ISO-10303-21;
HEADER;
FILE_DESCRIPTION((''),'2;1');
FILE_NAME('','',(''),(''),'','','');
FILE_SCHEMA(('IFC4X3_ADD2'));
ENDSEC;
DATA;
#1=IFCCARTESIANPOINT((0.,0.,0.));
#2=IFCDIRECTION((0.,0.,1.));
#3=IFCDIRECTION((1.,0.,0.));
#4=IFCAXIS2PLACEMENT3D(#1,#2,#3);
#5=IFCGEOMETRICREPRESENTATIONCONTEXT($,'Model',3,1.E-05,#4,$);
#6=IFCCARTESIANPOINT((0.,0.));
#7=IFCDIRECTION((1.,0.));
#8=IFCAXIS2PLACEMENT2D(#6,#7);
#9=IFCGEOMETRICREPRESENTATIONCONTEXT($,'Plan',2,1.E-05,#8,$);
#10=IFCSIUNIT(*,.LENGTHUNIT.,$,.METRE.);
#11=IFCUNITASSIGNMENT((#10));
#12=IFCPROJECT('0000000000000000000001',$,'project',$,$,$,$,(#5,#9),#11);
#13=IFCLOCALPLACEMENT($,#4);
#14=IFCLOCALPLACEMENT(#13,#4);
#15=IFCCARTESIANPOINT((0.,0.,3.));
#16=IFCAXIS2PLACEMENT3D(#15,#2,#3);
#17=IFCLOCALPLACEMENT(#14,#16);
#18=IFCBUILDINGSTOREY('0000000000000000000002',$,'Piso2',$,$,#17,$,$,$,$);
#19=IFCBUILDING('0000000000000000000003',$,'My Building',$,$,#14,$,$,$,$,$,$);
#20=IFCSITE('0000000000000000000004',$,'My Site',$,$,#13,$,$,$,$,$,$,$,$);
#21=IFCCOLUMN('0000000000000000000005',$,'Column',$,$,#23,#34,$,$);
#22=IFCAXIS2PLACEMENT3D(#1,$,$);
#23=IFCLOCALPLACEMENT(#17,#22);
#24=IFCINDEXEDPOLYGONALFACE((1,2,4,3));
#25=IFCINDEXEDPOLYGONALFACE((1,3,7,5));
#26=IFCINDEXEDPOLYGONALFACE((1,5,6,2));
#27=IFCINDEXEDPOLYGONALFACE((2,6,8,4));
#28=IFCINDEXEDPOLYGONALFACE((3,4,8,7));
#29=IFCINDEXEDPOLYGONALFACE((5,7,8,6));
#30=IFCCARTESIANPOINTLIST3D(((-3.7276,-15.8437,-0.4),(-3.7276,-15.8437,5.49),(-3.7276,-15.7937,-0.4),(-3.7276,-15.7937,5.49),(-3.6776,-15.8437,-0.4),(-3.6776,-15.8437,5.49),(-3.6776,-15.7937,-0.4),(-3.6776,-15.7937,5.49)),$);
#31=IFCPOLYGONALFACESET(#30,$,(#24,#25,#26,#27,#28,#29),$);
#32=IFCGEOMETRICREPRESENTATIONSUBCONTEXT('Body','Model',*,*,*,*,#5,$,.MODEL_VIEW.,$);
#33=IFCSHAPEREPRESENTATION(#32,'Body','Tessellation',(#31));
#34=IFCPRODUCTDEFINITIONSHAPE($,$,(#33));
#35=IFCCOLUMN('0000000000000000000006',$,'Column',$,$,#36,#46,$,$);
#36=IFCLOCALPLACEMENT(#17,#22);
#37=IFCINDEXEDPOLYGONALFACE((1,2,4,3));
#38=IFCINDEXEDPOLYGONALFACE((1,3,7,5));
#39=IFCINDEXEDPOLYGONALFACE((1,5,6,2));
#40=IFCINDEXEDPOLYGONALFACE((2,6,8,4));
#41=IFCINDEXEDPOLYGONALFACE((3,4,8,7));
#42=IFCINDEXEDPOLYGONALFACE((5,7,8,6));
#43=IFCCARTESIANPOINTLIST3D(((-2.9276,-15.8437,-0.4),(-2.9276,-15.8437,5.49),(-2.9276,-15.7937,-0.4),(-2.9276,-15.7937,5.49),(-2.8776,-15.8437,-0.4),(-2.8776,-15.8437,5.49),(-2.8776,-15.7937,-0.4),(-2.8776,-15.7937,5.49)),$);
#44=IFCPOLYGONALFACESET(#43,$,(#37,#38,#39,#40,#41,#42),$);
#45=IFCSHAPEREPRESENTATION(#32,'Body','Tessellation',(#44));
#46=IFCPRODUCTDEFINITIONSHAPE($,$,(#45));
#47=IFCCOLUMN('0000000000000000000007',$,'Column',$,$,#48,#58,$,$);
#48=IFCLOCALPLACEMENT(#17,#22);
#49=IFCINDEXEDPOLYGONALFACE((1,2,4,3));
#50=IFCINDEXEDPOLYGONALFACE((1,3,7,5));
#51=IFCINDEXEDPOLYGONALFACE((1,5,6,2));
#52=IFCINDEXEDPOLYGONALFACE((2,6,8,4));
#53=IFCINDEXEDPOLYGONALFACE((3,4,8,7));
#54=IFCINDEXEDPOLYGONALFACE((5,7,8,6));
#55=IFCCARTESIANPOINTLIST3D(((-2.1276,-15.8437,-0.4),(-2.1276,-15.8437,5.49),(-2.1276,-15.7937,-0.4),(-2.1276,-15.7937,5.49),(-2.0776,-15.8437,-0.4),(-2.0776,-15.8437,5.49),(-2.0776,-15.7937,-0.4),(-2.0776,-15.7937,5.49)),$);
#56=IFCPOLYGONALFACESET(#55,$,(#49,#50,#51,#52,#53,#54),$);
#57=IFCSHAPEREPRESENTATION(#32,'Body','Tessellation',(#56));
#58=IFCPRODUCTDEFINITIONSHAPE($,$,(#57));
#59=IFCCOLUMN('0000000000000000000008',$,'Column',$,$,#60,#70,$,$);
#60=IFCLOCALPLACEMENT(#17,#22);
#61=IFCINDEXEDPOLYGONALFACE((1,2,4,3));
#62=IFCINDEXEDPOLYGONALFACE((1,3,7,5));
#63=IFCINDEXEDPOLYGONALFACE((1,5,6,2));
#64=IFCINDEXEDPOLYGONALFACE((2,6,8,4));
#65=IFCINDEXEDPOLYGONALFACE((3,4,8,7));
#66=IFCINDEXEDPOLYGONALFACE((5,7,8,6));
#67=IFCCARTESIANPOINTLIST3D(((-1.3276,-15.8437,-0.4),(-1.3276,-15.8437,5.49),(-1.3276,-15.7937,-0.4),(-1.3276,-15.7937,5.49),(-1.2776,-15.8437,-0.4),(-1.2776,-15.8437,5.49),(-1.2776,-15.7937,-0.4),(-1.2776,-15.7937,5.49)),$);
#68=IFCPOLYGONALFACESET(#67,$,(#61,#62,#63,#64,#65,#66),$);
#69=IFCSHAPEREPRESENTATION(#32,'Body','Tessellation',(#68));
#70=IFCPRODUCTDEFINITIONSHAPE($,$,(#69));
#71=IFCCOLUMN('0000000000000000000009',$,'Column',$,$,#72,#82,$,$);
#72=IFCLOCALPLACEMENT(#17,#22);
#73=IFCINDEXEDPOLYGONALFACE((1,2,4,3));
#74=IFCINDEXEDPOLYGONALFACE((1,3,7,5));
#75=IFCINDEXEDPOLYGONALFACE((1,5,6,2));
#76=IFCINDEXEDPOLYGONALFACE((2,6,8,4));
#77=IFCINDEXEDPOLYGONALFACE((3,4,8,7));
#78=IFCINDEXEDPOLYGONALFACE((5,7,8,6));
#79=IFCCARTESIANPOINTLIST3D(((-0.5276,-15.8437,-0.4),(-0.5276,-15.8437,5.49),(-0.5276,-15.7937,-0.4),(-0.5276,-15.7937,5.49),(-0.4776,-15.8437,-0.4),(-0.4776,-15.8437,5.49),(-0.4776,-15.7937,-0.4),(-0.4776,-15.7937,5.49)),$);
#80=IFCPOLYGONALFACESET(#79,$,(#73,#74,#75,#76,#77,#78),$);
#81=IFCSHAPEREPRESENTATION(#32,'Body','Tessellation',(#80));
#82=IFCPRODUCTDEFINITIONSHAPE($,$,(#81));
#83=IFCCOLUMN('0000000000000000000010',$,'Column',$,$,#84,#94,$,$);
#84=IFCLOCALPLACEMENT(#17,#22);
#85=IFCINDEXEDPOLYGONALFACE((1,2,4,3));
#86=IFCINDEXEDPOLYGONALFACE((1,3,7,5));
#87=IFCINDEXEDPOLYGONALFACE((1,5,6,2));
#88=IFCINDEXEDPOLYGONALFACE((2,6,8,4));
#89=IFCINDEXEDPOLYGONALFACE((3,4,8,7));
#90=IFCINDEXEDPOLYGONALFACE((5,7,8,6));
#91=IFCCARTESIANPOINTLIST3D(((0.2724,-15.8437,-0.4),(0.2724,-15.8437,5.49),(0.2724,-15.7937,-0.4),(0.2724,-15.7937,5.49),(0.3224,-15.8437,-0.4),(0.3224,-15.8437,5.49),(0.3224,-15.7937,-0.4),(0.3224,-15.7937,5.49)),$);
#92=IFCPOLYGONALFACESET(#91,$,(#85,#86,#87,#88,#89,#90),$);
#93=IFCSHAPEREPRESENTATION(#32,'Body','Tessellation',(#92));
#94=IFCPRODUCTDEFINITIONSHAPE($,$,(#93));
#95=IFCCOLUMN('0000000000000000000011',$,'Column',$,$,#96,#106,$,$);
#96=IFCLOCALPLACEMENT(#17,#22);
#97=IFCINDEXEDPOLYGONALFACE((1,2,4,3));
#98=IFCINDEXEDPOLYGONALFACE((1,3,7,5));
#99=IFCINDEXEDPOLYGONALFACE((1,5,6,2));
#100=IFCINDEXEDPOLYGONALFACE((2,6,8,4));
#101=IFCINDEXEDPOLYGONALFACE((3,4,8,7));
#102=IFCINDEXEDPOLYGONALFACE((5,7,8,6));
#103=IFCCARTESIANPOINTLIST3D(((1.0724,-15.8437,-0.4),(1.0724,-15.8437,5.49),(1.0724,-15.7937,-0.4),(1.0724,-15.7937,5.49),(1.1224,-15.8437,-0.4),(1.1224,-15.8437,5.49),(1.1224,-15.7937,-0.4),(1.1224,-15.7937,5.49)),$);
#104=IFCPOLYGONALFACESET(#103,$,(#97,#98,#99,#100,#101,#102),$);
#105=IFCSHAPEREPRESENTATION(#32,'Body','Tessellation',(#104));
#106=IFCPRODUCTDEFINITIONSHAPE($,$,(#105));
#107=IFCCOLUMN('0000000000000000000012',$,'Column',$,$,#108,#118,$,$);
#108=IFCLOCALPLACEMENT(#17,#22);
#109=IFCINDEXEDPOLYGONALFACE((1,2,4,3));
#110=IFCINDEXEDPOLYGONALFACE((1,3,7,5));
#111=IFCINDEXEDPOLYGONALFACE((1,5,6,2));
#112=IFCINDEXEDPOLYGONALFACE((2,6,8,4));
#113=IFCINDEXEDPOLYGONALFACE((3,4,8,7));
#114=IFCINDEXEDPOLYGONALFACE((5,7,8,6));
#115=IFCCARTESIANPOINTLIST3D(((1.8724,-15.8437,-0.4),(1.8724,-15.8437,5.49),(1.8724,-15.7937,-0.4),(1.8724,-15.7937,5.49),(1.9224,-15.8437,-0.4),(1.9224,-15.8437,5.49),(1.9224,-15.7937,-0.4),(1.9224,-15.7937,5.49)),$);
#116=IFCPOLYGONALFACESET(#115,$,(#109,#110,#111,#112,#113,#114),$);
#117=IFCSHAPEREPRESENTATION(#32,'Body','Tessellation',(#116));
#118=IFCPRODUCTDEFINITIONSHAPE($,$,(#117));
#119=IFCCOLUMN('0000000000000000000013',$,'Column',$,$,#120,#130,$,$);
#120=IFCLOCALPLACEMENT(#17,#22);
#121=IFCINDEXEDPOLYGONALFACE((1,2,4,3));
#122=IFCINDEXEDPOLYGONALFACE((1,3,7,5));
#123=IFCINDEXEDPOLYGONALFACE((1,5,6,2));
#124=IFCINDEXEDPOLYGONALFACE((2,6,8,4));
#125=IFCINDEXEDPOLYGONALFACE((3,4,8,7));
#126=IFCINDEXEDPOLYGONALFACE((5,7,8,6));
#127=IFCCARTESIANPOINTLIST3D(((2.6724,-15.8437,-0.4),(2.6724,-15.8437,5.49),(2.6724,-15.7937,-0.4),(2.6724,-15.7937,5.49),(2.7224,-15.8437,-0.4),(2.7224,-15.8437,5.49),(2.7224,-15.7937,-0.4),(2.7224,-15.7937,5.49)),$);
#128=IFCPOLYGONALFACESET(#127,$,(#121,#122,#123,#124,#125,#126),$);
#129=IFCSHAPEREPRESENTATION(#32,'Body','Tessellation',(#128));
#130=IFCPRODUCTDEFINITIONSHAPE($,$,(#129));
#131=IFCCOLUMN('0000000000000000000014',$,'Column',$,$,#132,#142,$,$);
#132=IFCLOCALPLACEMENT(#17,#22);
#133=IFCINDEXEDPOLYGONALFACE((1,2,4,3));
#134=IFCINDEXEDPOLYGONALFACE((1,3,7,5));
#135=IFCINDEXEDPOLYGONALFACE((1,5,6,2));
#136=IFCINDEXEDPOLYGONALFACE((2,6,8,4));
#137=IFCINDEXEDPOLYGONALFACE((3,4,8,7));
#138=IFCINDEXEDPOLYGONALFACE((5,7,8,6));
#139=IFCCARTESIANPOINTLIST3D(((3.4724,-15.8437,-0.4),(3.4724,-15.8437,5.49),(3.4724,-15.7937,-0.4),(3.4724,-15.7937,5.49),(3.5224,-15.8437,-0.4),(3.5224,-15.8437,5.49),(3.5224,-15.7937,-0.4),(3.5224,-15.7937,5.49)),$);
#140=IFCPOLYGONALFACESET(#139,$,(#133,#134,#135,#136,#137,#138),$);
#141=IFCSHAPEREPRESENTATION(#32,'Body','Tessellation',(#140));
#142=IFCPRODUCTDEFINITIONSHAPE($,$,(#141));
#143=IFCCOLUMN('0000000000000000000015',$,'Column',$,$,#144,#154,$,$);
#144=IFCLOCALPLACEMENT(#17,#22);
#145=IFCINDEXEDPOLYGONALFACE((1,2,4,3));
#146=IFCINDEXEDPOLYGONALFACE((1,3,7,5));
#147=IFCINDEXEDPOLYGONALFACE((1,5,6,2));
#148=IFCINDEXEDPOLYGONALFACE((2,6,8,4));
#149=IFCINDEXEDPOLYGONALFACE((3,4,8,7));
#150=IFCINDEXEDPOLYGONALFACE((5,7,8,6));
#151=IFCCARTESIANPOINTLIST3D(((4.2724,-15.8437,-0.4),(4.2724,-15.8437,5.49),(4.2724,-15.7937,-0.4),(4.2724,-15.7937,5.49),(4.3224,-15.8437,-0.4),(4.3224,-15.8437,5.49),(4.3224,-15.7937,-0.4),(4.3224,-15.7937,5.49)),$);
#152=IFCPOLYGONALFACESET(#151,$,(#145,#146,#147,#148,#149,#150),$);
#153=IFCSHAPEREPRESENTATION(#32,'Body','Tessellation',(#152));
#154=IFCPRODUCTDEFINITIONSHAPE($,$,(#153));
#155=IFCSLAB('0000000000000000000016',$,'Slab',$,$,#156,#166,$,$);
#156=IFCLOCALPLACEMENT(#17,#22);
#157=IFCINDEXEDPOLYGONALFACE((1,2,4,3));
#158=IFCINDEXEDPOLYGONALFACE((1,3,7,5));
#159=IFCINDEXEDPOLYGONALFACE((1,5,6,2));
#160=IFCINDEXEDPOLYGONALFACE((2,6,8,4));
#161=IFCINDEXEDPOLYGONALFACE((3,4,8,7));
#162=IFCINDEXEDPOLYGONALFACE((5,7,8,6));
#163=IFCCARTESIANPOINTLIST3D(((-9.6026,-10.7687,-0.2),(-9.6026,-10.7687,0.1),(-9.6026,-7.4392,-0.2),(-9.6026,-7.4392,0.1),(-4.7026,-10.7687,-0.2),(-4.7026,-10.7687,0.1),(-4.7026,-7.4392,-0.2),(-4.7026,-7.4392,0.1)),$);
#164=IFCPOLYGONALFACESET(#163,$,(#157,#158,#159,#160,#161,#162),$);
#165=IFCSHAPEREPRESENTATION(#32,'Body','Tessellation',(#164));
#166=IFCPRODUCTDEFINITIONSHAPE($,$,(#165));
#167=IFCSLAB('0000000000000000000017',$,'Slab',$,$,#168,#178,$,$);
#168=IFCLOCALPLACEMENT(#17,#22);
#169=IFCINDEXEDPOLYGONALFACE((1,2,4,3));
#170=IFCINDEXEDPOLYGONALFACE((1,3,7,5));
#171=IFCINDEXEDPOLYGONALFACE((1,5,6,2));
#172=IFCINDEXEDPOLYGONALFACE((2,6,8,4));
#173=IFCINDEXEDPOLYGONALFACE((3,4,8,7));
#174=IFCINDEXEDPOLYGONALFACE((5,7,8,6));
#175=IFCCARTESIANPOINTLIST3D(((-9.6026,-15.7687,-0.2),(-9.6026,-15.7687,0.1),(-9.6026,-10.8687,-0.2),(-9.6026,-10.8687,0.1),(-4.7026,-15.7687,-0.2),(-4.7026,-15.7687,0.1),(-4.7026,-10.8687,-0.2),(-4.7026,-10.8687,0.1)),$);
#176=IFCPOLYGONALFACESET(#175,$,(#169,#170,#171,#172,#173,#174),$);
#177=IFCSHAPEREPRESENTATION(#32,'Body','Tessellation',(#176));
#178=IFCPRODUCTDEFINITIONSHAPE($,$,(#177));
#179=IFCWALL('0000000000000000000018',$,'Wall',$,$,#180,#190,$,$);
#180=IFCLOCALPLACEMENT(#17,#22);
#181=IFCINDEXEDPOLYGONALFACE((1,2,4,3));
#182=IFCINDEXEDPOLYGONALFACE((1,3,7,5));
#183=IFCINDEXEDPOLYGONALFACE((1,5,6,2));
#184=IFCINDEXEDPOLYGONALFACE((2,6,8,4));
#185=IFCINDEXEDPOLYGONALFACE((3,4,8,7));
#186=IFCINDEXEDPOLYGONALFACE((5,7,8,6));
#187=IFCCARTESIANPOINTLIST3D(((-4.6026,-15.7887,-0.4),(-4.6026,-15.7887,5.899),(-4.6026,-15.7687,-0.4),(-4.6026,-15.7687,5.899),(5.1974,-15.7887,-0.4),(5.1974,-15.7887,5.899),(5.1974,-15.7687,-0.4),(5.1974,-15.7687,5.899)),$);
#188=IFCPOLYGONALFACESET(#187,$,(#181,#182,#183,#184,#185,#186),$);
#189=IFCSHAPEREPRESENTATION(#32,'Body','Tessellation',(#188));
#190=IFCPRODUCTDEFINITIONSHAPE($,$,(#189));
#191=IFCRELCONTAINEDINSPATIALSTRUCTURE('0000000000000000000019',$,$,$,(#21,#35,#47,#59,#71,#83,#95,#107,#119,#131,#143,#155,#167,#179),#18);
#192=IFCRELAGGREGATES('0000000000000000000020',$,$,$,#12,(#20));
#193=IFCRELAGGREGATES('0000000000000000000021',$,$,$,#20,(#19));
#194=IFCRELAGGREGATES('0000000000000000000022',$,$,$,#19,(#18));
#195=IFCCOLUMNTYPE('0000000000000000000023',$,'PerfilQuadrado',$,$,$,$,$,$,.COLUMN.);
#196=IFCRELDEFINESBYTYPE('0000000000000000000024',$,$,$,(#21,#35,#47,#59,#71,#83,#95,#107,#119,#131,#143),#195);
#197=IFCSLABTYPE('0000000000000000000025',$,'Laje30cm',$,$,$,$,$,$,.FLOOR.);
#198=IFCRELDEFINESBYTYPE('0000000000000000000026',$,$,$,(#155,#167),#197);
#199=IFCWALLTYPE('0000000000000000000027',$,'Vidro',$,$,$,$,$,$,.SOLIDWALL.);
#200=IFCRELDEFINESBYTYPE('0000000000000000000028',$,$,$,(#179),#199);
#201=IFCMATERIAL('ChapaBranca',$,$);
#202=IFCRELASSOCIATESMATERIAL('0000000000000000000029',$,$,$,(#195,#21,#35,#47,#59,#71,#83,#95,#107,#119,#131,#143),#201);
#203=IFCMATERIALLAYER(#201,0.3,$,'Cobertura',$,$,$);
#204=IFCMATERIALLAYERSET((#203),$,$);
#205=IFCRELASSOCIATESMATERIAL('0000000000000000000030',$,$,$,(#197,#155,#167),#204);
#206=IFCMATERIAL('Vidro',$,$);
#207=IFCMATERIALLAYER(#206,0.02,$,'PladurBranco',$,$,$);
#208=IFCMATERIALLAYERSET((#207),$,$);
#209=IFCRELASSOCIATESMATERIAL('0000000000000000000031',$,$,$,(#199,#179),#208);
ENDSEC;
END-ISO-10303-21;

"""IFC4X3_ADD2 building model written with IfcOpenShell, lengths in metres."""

from ifc_helpers import new_model, si_unit, frame, origin_with_axes, origin_2d, origin_2d_with_axis, place, context, subcontext, project, spatial, line, indexed_curve, rectangle, outline, extrude, material, layer, layer_set, layer_usage, material_profile, profile_set, profile_usage, type_object, element, save


model = new_model("IFC4X3_ADD2")

# Units and contexts
model_context = context("Model", 3, precision=1e-05, world=origin_with_axes())
plan_context = context("Plan", 2, precision=1e-05, world=origin_2d_with_axis())
body_context = subcontext(model_context, "Body", "Model", "MODEL_VIEW")
ifc_project = project(units=[si_unit("LENGTHUNIT", "METRE")], contexts=[model_context, plan_context])

# Site, building, storey
site_placement = place(None, origin_with_axes())
site = spatial("IfcSite", under=ifc_project, at=site_placement, Name="My Site")
building_placement = place(site_placement, origin_with_axes())
building = spatial("IfcBuilding", under=site, at=building_placement, Name="My Building")
storey_placement = place(building_placement, frame((0.0, 0.0, 3.0), z_axis=(0.0, 0.0, 1.0), x_axis=(1.0, 0.0, 0.0)))
storey = spatial("IfcBuildingStorey", under=building, at=storey_placement, Name="Piso2")

# Columns
ifc_material_1 = material(Name="ChapaBranca")
ifc_material_profile = material_profile(ifc_material_1, rectangle(XDim=0.05, YDim=0.05, at=origin_2d()))
ifc_profile_set = profile_set([ifc_material_profile])
ifc_profile_usage_1 = profile_usage(ifc_profile_set, cardinal=5)
column_type = type_object("IfcColumnType", Name="PerfilQuadrado", PredefinedType="COLUMN", material=ifc_profile_set)
column_1_placement = place(storey_placement, frame((-3.7026, -15.8187, -0.4), z_axis=(0.0, 0.0, 1.0), x_axis=(0.0, 1.0, 0.0)))
element("IfcColumn", 1, at=column_1_placement, inside=storey, type_object=column_type, material=ifc_profile_usage_1, Name="Column", context=body_context, shape_type="SweptSolid", body=[
    extrude(rectangle(XDim=0.05, YDim=0.05, at=origin_2d()), origin_with_axes(), (0.0, 0.0, 1.0), 5.89),
])
ifc_profile_usage_2 = profile_usage(ifc_profile_set, cardinal=5)
column_2_placement = place(storey_placement, frame((-2.9026, -15.8187, -0.4), z_axis=(0.0, 0.0, 1.0), x_axis=(0.0, 1.0, 0.0)))
element("IfcColumn", 2, at=column_2_placement, inside=storey, type_object=column_type, material=ifc_profile_usage_2, Name="Column", context=body_context, shape_type="SweptSolid", body=[
    extrude(rectangle(XDim=0.05, YDim=0.05, at=origin_2d()), origin_with_axes(), (0.0, 0.0, 1.0), 5.89),
])
ifc_profile_usage_3 = profile_usage(ifc_profile_set, cardinal=5)
column_3_placement = place(storey_placement, frame((-2.1026, -15.8187, -0.4), z_axis=(0.0, 0.0, 1.0), x_axis=(0.0, 1.0, 0.0)))
element("IfcColumn", 3, at=column_3_placement, inside=storey, type_object=column_type, material=ifc_profile_usage_3, Name="Column", context=body_context, shape_type="SweptSolid", body=[
    extrude(rectangle(XDim=0.05, YDim=0.05, at=origin_2d()), origin_with_axes(), (0.0, 0.0, 1.0), 5.89),
])
ifc_profile_usage_4 = profile_usage(ifc_profile_set, cardinal=5)
column_4_placement = place(storey_placement, frame((-1.3026, -15.8187, -0.4), z_axis=(0.0, 0.0, 1.0), x_axis=(0.0, 1.0, 0.0)))
element("IfcColumn", 4, at=column_4_placement, inside=storey, type_object=column_type, material=ifc_profile_usage_4, Name="Column", context=body_context, shape_type="SweptSolid", body=[
    extrude(rectangle(XDim=0.05, YDim=0.05, at=origin_2d()), origin_with_axes(), (0.0, 0.0, 1.0), 5.89),
])
ifc_profile_usage_5 = profile_usage(ifc_profile_set, cardinal=5)
column_5_placement = place(storey_placement, frame((-0.5026, -15.8187, -0.4), z_axis=(0.0, 0.0, 1.0), x_axis=(0.0, 1.0, 0.0)))
element("IfcColumn", 5, at=column_5_placement, inside=storey, type_object=column_type, material=ifc_profile_usage_5, Name="Column", context=body_context, shape_type="SweptSolid", body=[
    extrude(rectangle(XDim=0.05, YDim=0.05, at=origin_2d()), origin_with_axes(), (0.0, 0.0, 1.0), 5.89),
])
ifc_profile_usage_6 = profile_usage(ifc_profile_set, cardinal=5)
column_6_placement = place(storey_placement, frame((0.2974, -15.8187, -0.4), z_axis=(0.0, 0.0, 1.0), x_axis=(0.0, 1.0, 0.0)))
element("IfcColumn", 6, at=column_6_placement, inside=storey, type_object=column_type, material=ifc_profile_usage_6, Name="Column", context=body_context, shape_type="SweptSolid", body=[
    extrude(rectangle(XDim=0.05, YDim=0.05, at=origin_2d()), origin_with_axes(), (0.0, 0.0, 1.0), 5.89),
])
ifc_profile_usage_7 = profile_usage(ifc_profile_set, cardinal=5)
column_7_placement = place(storey_placement, frame((1.0974, -15.8187, -0.4), z_axis=(0.0, 0.0, 1.0), x_axis=(0.0, 1.0, 0.0)))
element("IfcColumn", 7, at=column_7_placement, inside=storey, type_object=column_type, material=ifc_profile_usage_7, Name="Column", context=body_context, shape_type="SweptSolid", body=[
    extrude(rectangle(XDim=0.05, YDim=0.05, at=origin_2d()), origin_with_axes(), (0.0, 0.0, 1.0), 5.89),
])
ifc_profile_usage_8 = profile_usage(ifc_profile_set, cardinal=5)
column_8_placement = place(storey_placement, frame((1.8974, -15.8187, -0.4), z_axis=(0.0, 0.0, 1.0), x_axis=(0.0, 1.0, 0.0)))
element("IfcColumn", 8, at=column_8_placement, inside=storey, type_object=column_type, material=ifc_profile_usage_8, Name="Column", context=body_context, shape_type="SweptSolid", body=[
    extrude(rectangle(XDim=0.05, YDim=0.05, at=origin_2d()), origin_with_axes(), (0.0, 0.0, 1.0), 5.89),
])
ifc_profile_usage_9 = profile_usage(ifc_profile_set, cardinal=5)
column_9_placement = place(storey_placement, frame((2.6974, -15.8187, -0.4), z_axis=(0.0, 0.0, 1.0), x_axis=(0.0, 1.0, 0.0)))
element("IfcColumn", 9, at=column_9_placement, inside=storey, type_object=column_type, material=ifc_profile_usage_9, Name="Column", context=body_context, shape_type="SweptSolid", body=[
    extrude(rectangle(XDim=0.05, YDim=0.05, at=origin_2d()), origin_with_axes(), (0.0, 0.0, 1.0), 5.89),
])
ifc_profile_usage_10 = profile_usage(ifc_profile_set, cardinal=5)
column_10_placement = place(storey_placement, frame((3.4974, -15.8187, -0.4), z_axis=(0.0, 0.0, 1.0), x_axis=(0.0, 1.0, 0.0)))
element("IfcColumn", 10, at=column_10_placement, inside=storey, type_object=column_type, material=ifc_profile_usage_10, Name="Column", context=body_context, shape_type="SweptSolid", body=[
    extrude(rectangle(XDim=0.05, YDim=0.05, at=origin_2d()), origin_with_axes(), (0.0, 0.0, 1.0), 5.89),
])
ifc_profile_usage_11 = profile_usage(ifc_profile_set, cardinal=5)
column_11_placement = place(storey_placement, frame((4.2974, -15.8187, -0.4), z_axis=(0.0, 0.0, 1.0), x_axis=(0.0, 1.0, 0.0)))
element("IfcColumn", 11, at=column_11_placement, inside=storey, type_object=column_type, material=ifc_profile_usage_11, Name="Column", context=body_context, shape_type="SweptSolid", body=[
    extrude(rectangle(XDim=0.05, YDim=0.05, at=origin_2d()), origin_with_axes(), (0.0, 0.0, 1.0), 5.89),
])

# Slabs
ifc_layer_1 = layer(ifc_material_1, 0.3, Name="Cobertura")
ifc_layer_set_1 = layer_set([ifc_layer_1])
ifc_layer_usage_1 = layer_usage(ifc_layer_set_1, "AXIS3", "POSITIVE", 0.0)
slab_type_1 = type_object("IfcSlabType", Name="Laje30cm", PredefinedType="FLOOR", material=ifc_layer_set_1)
slab_1_placement = place(storey_placement, frame((-7.1526, -9.1039, -0.2), z_axis=(0.0, 0.0, 1.0), x_axis=(1.0, 0.0, 0.0)))
element("IfcSlab", 12, at=slab_1_placement, inside=storey, type_object=slab_type_1, material=ifc_layer_usage_1, Name="Slab", context=body_context, shape_type="SweptSolid", body=[
    extrude(outline(indexed_curve([(-1.6648, 2.45), (1.6648, 2.45), (1.6648, -2.45), (-1.6648, -2.45)], segments=[line(1, 2, 3, 4, 1)])), frame((0.0, 0.0, 0.0), z_axis=(0.0, 0.0, 1.0), x_axis=(0.0, -1.0, 0.0)), (0.0, 0.0, 1.0), 0.3),
])
ifc_layer_usage_2 = layer_usage(ifc_layer_set_1, "AXIS3", "POSITIVE", 0.0)
slab_2_placement = place(storey_placement, frame((-7.1526, -13.3187, -0.2), z_axis=(0.0, 0.0, 1.0), x_axis=(1.0, 0.0, 0.0)))
element("IfcSlab", 13, at=slab_2_placement, inside=storey, type_object=slab_type_1, material=ifc_layer_usage_2, Name="Slab", context=body_context, shape_type="SweptSolid", body=[
    extrude(outline(indexed_curve([(-2.45, 2.45), (2.45, 2.45), (2.45, -2.45), (-2.45, -2.45)], segments=[line(1, 2, 3, 4, 1)])), frame((0.0, 0.0, 0.0), z_axis=(0.0, 0.0, 1.0), x_axis=(0.0, -1.0, 0.0)), (0.0, 0.0, 1.0), 0.3),
])

# Wall
ifc_material_2 = material(Name="Vidro")
ifc_layer_2 = layer(ifc_material_2, 0.02, Name="PladurBranco")
ifc_layer_set_2 = layer_set([ifc_layer_2])
ifc_layer_usage_3 = layer_usage(ifc_layer_set_2, "AXIS2", "NEGATIVE", 0.0)
wall_type = type_object("IfcWallType", Name="Vidro", PredefinedType="SOLIDWALL", material=ifc_layer_set_2)
wall_placement = place(storey_placement, frame((-4.6026, -15.7687, -0.4), z_axis=(0.0, 0.0, 1.0), x_axis=(1.0, 0.0, 0.0)))
element("IfcWall", 14, at=wall_placement, inside=storey, type_object=wall_type, material=ifc_layer_usage_3, Name="Wall", context=body_context, shape_type="CSG", body=[
    extrude(outline(indexed_curve([(0.0, -0.02), (0.0, 0.0), (9.8, 0.0), (9.8, -0.02)], segments=[line(1, 2, 3, 4, 1)])), origin_with_axes(), (0.0, 0.0, 1.0), 6.299),
])

save(model, "model.ifc")
